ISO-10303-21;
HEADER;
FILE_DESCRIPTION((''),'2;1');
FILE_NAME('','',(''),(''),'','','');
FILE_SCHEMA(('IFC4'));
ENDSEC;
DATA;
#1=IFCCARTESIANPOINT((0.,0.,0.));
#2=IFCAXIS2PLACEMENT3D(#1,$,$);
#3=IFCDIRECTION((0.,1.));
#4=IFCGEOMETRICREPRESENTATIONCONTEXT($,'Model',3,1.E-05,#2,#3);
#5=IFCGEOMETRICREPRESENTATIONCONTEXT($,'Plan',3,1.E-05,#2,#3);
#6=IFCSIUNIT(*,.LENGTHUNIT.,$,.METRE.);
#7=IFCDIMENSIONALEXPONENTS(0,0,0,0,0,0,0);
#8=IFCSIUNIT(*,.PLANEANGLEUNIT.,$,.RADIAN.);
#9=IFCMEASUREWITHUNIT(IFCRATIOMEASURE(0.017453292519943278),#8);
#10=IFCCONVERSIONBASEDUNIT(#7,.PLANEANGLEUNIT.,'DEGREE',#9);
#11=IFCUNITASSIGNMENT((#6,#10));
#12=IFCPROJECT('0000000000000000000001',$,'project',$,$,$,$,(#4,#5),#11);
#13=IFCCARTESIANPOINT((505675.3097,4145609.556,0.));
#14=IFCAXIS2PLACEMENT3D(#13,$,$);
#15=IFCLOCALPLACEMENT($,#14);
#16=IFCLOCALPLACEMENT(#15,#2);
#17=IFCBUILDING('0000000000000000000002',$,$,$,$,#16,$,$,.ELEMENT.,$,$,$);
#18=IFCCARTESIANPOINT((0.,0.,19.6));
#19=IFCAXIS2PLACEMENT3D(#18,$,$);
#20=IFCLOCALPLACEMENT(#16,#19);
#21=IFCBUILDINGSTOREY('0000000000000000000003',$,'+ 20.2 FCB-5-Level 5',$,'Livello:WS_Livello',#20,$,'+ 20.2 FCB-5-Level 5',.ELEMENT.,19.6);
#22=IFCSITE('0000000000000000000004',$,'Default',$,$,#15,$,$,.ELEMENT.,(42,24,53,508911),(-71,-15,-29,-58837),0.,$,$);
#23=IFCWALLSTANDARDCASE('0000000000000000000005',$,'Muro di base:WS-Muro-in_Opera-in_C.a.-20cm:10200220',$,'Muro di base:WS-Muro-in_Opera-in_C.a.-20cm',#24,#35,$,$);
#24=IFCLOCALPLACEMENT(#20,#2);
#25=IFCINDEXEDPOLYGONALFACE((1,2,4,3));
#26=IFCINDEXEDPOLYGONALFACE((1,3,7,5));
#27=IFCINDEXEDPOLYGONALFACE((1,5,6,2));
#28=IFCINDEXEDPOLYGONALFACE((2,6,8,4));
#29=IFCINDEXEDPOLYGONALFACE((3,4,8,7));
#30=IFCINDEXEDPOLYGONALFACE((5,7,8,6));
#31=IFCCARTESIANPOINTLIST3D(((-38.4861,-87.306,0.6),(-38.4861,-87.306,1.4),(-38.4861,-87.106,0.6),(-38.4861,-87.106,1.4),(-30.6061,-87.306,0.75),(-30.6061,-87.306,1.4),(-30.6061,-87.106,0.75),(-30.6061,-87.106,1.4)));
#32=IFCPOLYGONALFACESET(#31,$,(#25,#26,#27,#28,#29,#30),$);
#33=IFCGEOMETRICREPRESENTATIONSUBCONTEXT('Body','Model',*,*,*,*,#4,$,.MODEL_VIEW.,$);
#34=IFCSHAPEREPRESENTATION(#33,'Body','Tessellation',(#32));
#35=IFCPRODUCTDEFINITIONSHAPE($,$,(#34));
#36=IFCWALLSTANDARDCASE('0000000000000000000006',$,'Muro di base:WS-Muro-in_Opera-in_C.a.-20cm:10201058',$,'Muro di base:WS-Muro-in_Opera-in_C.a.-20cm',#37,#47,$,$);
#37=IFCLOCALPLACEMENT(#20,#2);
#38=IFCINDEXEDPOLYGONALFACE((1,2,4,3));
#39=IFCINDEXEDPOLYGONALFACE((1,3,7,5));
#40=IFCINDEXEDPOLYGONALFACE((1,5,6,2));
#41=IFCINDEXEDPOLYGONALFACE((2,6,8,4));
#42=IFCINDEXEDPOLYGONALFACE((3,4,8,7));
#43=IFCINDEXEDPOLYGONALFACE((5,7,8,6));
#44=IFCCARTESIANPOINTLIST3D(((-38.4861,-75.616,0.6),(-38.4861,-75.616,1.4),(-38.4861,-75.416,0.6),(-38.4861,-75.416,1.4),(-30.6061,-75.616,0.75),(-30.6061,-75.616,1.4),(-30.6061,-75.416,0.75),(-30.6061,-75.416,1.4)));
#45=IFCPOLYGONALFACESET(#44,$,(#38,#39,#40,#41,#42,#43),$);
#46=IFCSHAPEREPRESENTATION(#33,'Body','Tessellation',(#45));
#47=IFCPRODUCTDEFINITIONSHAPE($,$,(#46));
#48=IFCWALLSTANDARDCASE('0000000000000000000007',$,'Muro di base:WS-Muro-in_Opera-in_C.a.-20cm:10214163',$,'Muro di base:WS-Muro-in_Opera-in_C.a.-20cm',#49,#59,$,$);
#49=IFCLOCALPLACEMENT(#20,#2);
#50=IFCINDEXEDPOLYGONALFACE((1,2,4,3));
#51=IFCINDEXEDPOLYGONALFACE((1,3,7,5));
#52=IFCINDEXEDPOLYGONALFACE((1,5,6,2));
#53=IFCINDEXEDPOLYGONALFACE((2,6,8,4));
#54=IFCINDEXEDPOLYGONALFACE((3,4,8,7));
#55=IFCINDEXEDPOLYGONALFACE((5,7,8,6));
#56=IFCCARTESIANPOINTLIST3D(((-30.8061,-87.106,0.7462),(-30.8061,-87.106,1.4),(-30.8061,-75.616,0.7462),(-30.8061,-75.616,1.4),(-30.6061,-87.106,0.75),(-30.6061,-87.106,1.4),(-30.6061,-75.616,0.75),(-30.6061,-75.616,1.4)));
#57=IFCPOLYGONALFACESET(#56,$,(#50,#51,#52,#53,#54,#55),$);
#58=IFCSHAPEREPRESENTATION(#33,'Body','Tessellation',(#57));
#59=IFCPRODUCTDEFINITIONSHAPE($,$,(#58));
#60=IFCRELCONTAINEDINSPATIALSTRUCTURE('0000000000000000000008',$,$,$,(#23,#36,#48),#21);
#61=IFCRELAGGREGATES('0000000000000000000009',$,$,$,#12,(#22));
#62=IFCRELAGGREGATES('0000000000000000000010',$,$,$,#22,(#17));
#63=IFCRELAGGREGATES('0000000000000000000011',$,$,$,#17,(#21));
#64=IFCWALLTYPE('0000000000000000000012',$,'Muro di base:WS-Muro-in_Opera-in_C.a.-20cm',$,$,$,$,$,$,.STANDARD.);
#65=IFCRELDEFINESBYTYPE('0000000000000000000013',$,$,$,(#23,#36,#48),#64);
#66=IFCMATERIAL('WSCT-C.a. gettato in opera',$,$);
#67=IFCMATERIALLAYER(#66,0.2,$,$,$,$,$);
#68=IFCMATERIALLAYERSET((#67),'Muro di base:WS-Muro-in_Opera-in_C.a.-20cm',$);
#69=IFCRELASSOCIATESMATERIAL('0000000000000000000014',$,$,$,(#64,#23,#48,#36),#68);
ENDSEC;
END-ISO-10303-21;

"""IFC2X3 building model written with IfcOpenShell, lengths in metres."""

from ifc_helpers import new_model, entity, si_unit, converted_unit, direction, frame, frame_2d, origin, place, context, subcontext, project, spatial, polyline, rectangle, extrude, clip, bounded_halfspace, material, layer, layer_set, layer_usage, type_object, element, save


model = new_model("IFC2X3")

# Units and contexts
model_context = context("Model", 3, precision=1e-05, world=origin(), true_north=direction((0.0, 1.0)))
plan_context = context("Plan", 3, precision=1e-05, world=origin(), true_north=direction((0.0, 1.0)))
body_context = subcontext(model_context, "Body", "Model", "MODEL_VIEW")
ifc_project = project(units=[si_unit("LENGTHUNIT", "METRE"), converted_unit("PLANEANGLEUNIT", "DEGREE", entity("IfcRatioMeasure", 0.017453292519943278), si_unit("PLANEANGLEUNIT", "RADIAN"), dimensions=[0, 0, 0, 0, 0, 0, 0])], contexts=[model_context, plan_context])

# Site, building, storey
site_placement = place(None, frame((505675.3097, 4145609.556, 0.0)))
site = spatial("IfcSite", under=ifc_project, at=site_placement, Name="Default", CompositionType="ELEMENT", RefLatitude=(42, 24, 53, 508911), RefLongitude=(-71, -15, -29, -58837), RefElevation=0.0)
building_placement = place(site_placement, origin())
building = spatial("IfcBuilding", under=site, at=building_placement, CompositionType="ELEMENT")
storey_placement = place(building_placement, frame((0.0, 0.0, 19.6)))
storey = spatial("IfcBuildingStorey", under=building, at=storey_placement, Name="+ 20.2 FCB-5-Level 5", ObjectType="Livello:WS_Livello", LongName="+ 20.2 FCB-5-Level 5", CompositionType="ELEMENT", Elevation=19.6)

# Walls
ifc_material_1 = material(Name="WSCT-C.a. gettato in opera")
ifc_layer = layer(ifc_material_1, 0.2)
ifc_layer_set = layer_set([ifc_layer], Name="Muro di base:WS-Muro-in_Opera-in_C.a.-20cm")
ifc_layer_usage_1 = layer_usage(ifc_layer_set, "AXIS2", "NEGATIVE", 0.1)
wall_type = type_object("IfcWallType", Name="Muro di base:WS-Muro-in_Opera-in_C.a.-20cm", PredefinedType="STANDARD", material=ifc_layer_set)
wall_1_placement = place(storey_placement, frame((-38.4861, -87.206, 0.6)))
element("IfcWallStandardCase", 1, at=wall_1_placement, inside=storey, type_object=wall_type, material=ifc_layer_usage_1, Name="Muro di base:WS-Muro-in_Opera-in_C.a.-20cm:10200220", ObjectType="Muro di base:WS-Muro-in_Opera-in_C.a.-20cm", context=body_context, shape_type="Clipping", body=[
    clip(extrude(rectangle(XDim=7.88, YDim=0.2, at=frame_2d((3.94, 0.0), x_axis=(-1.0, 0.0))), origin(), (0.0, 0.0, 1.0), 0.8), bounded_halfspace(frame((7.88, -0.1, 0.15), z_axis=(-0.019032, 0.0, 0.999819), x_axis=(-0.999819, 0.0, -0.019032)), True, frame((7.88, -0.1, 0.15)), polyline([(0.0, 0.0), (0.0, 0.2), (-0.2, 0.2), (-7.88, 0.2), (-7.88, 0.0), (0.0, 0.0)]))),
])
ifc_layer_usage_2 = layer_usage(ifc_layer_set, "AXIS2", "POSITIVE", -0.1)
wall_2_placement = place(storey_placement, frame((-38.4861, -75.516, 0.6)))
element("IfcWallStandardCase", 2, at=wall_2_placement, inside=storey, type_object=wall_type, material=ifc_layer_usage_2, Name="Muro di base:WS-Muro-in_Opera-in_C.a.-20cm:10201058", ObjectType="Muro di base:WS-Muro-in_Opera-in_C.a.-20cm", context=body_context, shape_type="Clipping", body=[
    clip(extrude(rectangle(XDim=7.88, YDim=0.2, at=frame_2d((3.94, 0.0), x_axis=(-1.0, 0.0))), origin(), (0.0, 0.0, 1.0), 0.8), bounded_halfspace(frame((7.88, -0.1, 0.15), z_axis=(-0.019032, 0.0, 0.999819), x_axis=(-0.999819, 0.0, -0.019032)), True, frame((7.88, -0.1, 0.15)), polyline([(0.0, 0.0), (0.0, 0.2), (-7.88, 0.2), (-7.88, 0.0), (-0.2, 0.0), (0.0, 0.0)]))),
])
wall_3_placement = place(storey_placement, frame((-30.7061, -87.106, 0.7462), z_axis=(0.0, 0.0, 1.0), x_axis=(0.0, 1.0, 0.0)))
element("IfcWallStandardCase", 3, at=wall_3_placement, inside=storey, type_object=wall_type, material=ifc_layer_usage_1, Name="Muro di base:WS-Muro-in_Opera-in_C.a.-20cm:10214163", ObjectType="Muro di base:WS-Muro-in_Opera-in_C.a.-20cm", context=body_context, shape_type="Clipping", body=[
    clip(extrude(rectangle(XDim=11.49, YDim=0.2, at=frame_2d((5.745, 0.0), x_axis=(-1.0, 0.0))), origin(), (0.0, 0.0, 1.0), 0.6538), bounded_halfspace(frame((11.49, -0.1, 0.0038), z_axis=(0.0, 0.019032, 0.999819), x_axis=(0.0, 0.999819, -0.019032)), True, frame((11.49, -0.1, 0.0038)), polyline([(0.0, 0.0), (0.0, 0.2), (-11.49, 0.2), (-11.49, 0.0), (0.0, 0.0)]))),
])

save(model, "model.ifc")
